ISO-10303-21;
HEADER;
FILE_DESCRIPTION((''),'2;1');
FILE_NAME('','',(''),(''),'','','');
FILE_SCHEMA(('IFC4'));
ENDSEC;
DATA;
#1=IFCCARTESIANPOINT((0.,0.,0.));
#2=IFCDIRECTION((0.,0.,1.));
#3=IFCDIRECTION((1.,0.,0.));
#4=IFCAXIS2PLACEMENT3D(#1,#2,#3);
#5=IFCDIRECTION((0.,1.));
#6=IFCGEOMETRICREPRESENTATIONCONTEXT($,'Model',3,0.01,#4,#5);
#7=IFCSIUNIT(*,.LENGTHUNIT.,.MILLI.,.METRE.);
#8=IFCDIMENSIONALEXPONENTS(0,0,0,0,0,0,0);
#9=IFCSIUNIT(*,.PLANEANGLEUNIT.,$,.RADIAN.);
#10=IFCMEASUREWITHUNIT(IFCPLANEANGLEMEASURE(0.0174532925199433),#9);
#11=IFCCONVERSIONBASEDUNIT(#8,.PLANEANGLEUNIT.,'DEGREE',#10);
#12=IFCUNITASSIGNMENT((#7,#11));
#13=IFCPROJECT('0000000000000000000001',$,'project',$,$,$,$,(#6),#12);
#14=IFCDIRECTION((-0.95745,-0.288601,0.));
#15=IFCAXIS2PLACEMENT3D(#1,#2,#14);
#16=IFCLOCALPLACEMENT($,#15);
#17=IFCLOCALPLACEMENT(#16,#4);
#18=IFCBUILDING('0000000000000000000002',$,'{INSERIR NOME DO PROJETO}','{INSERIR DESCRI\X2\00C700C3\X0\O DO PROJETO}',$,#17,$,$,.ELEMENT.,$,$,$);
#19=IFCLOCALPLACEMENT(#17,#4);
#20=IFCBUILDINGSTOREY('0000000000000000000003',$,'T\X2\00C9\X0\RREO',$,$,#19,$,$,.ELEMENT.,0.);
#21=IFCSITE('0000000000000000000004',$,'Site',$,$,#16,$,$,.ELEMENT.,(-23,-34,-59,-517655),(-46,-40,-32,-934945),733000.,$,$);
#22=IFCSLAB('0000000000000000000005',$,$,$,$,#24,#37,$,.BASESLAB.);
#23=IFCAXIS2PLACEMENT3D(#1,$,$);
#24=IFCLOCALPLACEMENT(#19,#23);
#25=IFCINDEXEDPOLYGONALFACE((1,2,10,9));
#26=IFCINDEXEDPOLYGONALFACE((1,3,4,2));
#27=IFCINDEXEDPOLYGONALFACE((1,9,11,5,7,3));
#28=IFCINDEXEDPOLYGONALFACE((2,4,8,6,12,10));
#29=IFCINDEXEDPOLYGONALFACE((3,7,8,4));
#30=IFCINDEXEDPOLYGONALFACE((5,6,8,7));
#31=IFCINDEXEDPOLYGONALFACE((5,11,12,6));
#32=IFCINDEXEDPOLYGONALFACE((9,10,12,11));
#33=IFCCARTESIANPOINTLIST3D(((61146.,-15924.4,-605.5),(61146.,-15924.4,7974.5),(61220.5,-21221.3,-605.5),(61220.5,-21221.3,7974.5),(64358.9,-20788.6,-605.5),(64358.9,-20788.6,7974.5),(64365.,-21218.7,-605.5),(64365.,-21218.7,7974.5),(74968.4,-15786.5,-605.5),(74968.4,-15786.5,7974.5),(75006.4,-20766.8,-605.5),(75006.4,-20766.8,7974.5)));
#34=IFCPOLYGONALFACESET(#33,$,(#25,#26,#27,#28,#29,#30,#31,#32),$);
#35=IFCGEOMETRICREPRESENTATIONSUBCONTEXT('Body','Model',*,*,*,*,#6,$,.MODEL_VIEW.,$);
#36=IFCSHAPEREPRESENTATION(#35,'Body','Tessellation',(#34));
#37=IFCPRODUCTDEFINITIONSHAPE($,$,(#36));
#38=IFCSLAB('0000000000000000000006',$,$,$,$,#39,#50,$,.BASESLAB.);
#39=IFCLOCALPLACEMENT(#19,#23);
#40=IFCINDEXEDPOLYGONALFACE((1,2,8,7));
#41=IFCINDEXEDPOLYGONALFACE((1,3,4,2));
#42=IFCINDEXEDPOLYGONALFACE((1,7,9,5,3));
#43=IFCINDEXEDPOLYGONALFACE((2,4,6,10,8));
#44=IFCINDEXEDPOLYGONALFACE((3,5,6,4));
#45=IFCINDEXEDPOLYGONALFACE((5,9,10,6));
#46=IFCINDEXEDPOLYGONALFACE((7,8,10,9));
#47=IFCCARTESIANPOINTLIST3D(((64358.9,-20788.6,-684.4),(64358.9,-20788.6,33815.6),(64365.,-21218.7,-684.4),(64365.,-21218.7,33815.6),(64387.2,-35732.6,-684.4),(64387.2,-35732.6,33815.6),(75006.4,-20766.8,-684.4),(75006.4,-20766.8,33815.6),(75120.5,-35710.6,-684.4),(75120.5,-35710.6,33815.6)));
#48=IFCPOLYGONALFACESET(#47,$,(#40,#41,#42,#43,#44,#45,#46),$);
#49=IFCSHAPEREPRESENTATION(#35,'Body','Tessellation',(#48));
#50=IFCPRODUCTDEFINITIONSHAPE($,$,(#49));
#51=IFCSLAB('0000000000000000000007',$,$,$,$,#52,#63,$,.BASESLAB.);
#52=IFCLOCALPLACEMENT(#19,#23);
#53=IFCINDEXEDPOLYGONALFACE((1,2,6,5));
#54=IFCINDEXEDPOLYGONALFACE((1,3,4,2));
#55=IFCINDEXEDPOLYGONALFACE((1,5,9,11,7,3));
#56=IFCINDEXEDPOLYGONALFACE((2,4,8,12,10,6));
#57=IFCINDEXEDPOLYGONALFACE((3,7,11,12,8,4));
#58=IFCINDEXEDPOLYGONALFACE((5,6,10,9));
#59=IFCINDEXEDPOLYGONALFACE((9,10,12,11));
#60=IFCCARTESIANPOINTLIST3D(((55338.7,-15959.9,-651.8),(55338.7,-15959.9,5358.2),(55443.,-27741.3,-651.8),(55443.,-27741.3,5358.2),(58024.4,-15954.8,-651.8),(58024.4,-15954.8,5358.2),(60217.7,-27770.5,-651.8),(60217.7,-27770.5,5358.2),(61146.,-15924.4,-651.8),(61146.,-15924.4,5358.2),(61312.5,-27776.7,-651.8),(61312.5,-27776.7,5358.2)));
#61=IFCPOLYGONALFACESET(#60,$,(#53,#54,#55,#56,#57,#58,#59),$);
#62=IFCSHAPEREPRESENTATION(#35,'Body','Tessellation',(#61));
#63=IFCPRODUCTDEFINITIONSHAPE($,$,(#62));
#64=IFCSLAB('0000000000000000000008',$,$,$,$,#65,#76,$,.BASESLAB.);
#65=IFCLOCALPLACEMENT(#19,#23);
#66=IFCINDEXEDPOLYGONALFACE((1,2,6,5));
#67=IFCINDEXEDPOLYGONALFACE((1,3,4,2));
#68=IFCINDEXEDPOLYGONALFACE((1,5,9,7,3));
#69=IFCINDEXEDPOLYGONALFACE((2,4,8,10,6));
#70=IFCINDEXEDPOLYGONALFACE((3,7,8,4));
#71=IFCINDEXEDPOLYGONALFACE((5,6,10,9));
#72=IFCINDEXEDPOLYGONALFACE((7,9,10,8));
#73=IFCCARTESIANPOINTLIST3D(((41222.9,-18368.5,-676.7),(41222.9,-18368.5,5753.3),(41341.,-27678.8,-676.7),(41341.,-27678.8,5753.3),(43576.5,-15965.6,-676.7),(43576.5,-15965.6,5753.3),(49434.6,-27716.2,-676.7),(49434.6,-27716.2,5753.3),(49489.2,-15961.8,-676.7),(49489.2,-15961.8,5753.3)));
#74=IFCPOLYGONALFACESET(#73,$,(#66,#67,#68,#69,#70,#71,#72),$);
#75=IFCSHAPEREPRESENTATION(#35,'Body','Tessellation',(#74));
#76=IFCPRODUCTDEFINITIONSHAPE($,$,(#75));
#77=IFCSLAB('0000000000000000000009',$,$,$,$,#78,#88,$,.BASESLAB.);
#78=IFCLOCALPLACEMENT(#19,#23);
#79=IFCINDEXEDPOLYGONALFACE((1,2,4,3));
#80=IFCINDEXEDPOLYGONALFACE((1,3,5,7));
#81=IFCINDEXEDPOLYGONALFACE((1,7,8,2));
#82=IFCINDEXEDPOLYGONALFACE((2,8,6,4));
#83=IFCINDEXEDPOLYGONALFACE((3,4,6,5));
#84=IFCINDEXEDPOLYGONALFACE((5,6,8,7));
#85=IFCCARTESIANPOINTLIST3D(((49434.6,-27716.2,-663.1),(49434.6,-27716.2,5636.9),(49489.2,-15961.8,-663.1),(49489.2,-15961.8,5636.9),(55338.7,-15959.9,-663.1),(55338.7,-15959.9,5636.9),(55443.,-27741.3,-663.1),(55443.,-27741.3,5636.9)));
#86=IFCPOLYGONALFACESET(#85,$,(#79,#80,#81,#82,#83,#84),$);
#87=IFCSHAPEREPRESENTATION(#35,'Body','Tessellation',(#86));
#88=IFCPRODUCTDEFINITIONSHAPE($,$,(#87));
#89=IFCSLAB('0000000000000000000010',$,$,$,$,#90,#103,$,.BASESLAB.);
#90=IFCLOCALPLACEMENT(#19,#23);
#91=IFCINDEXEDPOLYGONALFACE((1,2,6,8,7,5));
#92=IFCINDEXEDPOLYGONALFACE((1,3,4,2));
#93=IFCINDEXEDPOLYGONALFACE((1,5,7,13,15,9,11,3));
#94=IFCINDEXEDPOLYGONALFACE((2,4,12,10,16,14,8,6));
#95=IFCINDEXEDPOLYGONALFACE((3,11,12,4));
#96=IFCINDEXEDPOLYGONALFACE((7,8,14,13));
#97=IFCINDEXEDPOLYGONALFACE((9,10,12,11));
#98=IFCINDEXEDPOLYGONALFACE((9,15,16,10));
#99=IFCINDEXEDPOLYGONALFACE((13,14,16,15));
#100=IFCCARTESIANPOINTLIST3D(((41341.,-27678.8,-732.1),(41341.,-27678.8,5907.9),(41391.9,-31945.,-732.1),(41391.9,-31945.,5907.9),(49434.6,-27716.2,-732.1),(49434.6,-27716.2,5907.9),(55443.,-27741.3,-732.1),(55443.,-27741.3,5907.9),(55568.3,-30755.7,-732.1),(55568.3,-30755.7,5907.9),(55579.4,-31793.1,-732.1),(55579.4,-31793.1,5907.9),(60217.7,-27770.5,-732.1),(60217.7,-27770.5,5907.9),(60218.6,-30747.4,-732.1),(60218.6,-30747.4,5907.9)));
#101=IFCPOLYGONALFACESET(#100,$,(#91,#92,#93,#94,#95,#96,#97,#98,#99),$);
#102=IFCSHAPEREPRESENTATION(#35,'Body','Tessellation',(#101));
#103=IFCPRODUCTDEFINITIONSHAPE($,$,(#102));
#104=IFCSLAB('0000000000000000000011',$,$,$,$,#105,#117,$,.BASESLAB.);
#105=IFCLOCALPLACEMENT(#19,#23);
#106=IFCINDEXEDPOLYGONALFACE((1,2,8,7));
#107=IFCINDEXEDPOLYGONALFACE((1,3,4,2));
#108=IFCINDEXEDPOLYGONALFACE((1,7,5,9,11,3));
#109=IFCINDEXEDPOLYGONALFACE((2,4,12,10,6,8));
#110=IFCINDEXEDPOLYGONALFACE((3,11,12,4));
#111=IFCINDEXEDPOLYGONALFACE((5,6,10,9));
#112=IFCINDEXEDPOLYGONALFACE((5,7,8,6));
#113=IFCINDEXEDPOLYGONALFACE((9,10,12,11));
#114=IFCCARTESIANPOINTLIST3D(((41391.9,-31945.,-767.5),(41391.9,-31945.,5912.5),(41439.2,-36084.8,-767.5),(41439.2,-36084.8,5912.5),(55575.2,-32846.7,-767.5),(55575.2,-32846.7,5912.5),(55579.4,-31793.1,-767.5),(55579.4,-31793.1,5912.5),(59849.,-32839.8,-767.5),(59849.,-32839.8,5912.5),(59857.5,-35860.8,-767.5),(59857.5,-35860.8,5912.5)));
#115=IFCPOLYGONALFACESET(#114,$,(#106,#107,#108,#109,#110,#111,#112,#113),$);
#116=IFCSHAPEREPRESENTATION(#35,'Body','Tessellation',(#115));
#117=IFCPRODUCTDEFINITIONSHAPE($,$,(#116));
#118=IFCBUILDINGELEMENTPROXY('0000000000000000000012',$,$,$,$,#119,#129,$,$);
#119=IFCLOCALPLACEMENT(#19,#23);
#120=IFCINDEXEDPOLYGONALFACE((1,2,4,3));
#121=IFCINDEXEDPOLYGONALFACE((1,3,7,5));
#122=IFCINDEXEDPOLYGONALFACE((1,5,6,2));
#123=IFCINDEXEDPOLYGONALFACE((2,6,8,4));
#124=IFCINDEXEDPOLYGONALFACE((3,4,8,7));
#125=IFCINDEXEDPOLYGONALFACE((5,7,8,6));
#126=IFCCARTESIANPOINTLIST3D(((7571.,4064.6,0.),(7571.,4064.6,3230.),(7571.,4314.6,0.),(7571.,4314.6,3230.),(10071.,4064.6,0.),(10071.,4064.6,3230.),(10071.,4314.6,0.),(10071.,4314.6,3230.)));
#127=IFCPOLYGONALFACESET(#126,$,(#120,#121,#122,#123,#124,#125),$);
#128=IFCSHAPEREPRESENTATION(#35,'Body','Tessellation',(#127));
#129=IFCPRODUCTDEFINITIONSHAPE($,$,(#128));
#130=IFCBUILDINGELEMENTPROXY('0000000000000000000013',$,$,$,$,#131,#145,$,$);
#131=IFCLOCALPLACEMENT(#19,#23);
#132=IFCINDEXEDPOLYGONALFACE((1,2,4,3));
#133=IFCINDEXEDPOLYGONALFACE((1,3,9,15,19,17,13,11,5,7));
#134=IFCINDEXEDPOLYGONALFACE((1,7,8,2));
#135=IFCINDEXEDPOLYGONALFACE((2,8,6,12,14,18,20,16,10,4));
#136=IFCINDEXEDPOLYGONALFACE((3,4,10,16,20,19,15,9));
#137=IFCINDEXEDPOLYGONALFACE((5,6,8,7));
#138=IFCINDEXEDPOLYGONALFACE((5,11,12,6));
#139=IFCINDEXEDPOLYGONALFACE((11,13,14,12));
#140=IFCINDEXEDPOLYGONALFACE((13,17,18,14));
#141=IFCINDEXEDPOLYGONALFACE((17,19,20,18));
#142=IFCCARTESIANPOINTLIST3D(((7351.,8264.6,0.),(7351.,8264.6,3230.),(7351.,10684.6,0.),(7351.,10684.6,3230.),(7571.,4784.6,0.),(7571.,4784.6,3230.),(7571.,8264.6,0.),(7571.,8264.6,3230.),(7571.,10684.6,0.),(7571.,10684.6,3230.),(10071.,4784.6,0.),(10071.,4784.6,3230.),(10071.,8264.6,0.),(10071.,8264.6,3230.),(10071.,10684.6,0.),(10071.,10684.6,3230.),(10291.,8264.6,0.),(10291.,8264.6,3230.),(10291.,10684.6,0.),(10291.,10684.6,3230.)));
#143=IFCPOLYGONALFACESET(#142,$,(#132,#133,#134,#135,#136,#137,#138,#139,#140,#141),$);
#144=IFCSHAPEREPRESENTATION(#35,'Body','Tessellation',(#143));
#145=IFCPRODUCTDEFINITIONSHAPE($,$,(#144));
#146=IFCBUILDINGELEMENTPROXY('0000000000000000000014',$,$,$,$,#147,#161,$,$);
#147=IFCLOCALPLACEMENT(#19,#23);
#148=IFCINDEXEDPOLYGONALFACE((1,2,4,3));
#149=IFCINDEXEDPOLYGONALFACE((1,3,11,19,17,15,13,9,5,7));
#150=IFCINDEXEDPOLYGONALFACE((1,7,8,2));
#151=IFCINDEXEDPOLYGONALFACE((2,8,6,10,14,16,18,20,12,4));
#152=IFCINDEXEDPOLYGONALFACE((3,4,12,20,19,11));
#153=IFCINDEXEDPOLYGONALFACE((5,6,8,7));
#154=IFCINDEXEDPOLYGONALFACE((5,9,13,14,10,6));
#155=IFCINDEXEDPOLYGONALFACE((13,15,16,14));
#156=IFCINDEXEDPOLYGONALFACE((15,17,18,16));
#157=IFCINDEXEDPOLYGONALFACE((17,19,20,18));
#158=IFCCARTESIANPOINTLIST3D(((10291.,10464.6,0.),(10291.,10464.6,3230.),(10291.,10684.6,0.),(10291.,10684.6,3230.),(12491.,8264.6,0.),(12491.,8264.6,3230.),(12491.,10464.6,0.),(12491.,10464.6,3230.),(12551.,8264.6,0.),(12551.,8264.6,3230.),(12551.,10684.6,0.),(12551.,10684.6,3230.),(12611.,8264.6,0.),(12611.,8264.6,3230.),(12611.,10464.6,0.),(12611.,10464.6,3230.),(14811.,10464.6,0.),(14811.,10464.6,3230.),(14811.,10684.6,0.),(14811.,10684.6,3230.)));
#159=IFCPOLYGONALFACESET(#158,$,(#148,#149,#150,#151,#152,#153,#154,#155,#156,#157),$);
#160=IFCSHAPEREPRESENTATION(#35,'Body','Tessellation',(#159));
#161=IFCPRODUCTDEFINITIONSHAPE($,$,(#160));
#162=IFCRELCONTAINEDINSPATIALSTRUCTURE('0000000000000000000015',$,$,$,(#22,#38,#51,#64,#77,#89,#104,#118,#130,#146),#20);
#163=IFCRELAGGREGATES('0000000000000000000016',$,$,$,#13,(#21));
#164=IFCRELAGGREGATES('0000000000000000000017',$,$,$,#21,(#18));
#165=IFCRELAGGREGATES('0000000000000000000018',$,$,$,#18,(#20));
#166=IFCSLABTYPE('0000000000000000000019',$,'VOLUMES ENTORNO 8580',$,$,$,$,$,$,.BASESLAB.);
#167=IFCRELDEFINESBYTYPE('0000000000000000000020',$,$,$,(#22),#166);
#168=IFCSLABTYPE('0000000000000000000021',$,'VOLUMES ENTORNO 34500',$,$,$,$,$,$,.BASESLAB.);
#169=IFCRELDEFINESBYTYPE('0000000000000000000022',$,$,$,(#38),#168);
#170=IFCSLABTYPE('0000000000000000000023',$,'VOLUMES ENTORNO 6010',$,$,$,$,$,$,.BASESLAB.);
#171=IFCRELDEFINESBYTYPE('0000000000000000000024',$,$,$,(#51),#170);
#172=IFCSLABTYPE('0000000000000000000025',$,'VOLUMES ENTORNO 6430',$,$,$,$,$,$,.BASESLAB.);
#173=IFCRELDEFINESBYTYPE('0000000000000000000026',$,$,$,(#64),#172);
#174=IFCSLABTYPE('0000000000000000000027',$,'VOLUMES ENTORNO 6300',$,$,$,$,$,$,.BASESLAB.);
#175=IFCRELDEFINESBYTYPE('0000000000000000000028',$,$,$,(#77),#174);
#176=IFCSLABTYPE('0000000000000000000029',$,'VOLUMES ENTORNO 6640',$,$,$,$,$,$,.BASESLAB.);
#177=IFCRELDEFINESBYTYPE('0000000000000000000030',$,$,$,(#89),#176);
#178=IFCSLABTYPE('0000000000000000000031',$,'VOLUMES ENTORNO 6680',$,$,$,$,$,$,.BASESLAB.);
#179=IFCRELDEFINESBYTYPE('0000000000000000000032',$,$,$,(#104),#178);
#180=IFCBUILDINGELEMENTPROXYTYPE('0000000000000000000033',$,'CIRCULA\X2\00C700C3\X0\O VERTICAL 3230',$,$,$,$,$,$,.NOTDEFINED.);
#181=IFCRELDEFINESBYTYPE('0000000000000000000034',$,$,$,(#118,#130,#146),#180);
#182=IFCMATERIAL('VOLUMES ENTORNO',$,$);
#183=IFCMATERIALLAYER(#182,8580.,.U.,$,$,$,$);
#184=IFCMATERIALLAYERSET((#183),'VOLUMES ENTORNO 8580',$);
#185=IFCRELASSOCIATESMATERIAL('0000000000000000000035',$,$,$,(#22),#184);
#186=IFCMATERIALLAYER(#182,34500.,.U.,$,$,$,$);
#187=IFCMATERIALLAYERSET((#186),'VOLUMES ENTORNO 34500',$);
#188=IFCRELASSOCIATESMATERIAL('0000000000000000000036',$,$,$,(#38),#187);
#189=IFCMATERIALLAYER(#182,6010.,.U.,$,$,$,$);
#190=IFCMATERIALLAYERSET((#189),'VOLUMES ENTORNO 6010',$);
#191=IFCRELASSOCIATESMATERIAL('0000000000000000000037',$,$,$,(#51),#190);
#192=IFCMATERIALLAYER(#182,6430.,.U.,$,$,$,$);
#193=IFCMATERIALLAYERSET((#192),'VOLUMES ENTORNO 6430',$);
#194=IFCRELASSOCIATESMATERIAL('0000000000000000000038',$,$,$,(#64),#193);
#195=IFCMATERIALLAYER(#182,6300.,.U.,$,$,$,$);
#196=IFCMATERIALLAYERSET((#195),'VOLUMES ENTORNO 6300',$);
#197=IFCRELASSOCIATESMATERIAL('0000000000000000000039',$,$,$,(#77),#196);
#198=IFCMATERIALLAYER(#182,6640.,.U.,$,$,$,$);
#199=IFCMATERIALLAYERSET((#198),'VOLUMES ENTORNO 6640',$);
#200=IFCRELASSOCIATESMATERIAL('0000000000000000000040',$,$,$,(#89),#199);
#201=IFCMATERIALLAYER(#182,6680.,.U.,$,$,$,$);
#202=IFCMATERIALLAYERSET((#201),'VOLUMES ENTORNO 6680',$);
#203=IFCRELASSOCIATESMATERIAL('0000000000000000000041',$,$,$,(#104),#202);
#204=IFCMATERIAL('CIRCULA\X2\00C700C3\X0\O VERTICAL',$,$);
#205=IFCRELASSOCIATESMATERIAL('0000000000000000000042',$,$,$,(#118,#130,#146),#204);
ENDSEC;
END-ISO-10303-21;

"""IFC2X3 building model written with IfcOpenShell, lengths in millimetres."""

from ifc_helpers import new_model, entity, si_unit, converted_unit, direction, frame, origin_with_axes, place, context, subcontext, project, spatial, polyline, outline, extrude, material, layer, layer_set, layer_usage, type_object, element, save


model = new_model("IFC2X3")

# Units and contexts
model_context = context("Model", 3, precision=0.01, world=origin_with_axes(), true_north=direction((0.0, 1.0)))
body_context = subcontext(model_context, "Body", "Model", "MODEL_VIEW")
ifc_project = project(units=[si_unit("LENGTHUNIT", "METRE", prefix="MILLI"), converted_unit("PLANEANGLEUNIT", "DEGREE", entity("IfcPlaneAngleMeasure", 0.0174532925199433), si_unit("PLANEANGLEUNIT", "RADIAN"), dimensions=[0, 0, 0, 0, 0, 0, 0])], contexts=[model_context])

# Site, building, storey
site_placement = place(None, frame((0.0, 0.0, 0.0), z_axis=(0.0, 0.0, 1.0), x_axis=(-0.95745, -0.288601, 0.0)))
site = spatial("IfcSite", under=ifc_project, at=site_placement, Name="Site", CompositionType="ELEMENT", RefLatitude=(-23, -34, -59, -517655), RefLongitude=(-46, -40, -32, -934945), RefElevation=733000.0)
building_placement = place(site_placement, origin_with_axes())
building = spatial("IfcBuilding", under=site, at=building_placement, Name="{INSERIR NOME DO PROJETO}", Description="{INSERIR DESCRIÇÃO DO PROJETO}", CompositionType="ELEMENT")
storey_placement = place(building_placement, origin_with_axes())
storey = spatial("IfcBuildingStorey", under=building, at=storey_placement, Name="TÉRREO", CompositionType="ELEMENT", Elevation=0.0)

# Slabs
ifc_material_1 = material(Name="VOLUMES ENTORNO")
ifc_layer_1 = layer(ifc_material_1, 8580.0, ventilated="UNKNOWN")
ifc_layer_set_1 = layer_set([ifc_layer_1], Name="VOLUMES ENTORNO 8580")
ifc_layer_usage_1 = layer_usage(ifc_layer_set_1, "AXIS3", "NEGATIVE", 8580.0)
slab_type_1 = type_object("IfcSlabType", Name="VOLUMES ENTORNO 8580", PredefinedType="BASESLAB")
slab_1_placement = place(storey_placement, frame((61220.5, -21221.3, -605.5), z_axis=(0.0, 0.0, 1.0), x_axis=(1.0, 0.0, 0.0)))
element("IfcSlab", 1, at=slab_1_placement, inside=storey, type_object=slab_type_1, material=ifc_layer_usage_1, PredefinedType="BASESLAB", context=body_context, shape_type="SweptSolid", body=[
    extrude(outline(polyline([(0.0, 0.0), (3144.5, 2.6), (3138.4, 432.7), (13785.9, 454.5), (13747.9, 5434.7), (-74.5, 5296.9), (0.0, 0.0)])), origin_with_axes(), (0.0, 0.0, 1.0), 8580.0),
])
ifc_layer_2 = layer(ifc_material_1, 34500.0, ventilated="UNKNOWN")
ifc_layer_set_2 = layer_set([ifc_layer_2], Name="VOLUMES ENTORNO 34500")
ifc_layer_usage_2 = layer_usage(ifc_layer_set_2, "AXIS3", "NEGATIVE", 34500.0)
slab_type_2 = type_object("IfcSlabType", Name="VOLUMES ENTORNO 34500", PredefinedType="BASESLAB")
slab_2_placement = place(storey_placement, frame((64387.2, -35732.6, -684.4), z_axis=(0.0, 0.0, 1.0), x_axis=(1.0, 0.0, 0.0)))
element("IfcSlab", 2, at=slab_2_placement, inside=storey, type_object=slab_type_2, material=ifc_layer_usage_2, PredefinedType="BASESLAB", context=body_context, shape_type="SweptSolid", body=[
    extrude(outline(polyline([(0.0, 0.0), (10733.2, 22.0), (10619.1, 14965.9), (-28.3, 14944.1), (-22.2, 14514.0), (0.0, 0.0)])), origin_with_axes(), (0.0, 0.0, 1.0), 34500.0),
])
ifc_layer_3 = layer(ifc_material_1, 6010.0, ventilated="UNKNOWN")
ifc_layer_set_3 = layer_set([ifc_layer_3], Name="VOLUMES ENTORNO 6010")
ifc_layer_usage_3 = layer_usage(ifc_layer_set_3, "AXIS3", "NEGATIVE", 6010.0)
slab_type_3 = type_object("IfcSlabType", Name="VOLUMES ENTORNO 6010", PredefinedType="BASESLAB")
slab_3_placement = place(storey_placement, frame((61312.5, -27776.7, -651.8), z_axis=(0.0, 0.0, 1.0), x_axis=(1.0, 0.0, 0.0)))
element("IfcSlab", 3, at=slab_3_placement, inside=storey, type_object=slab_type_3, material=ifc_layer_usage_3, PredefinedType="BASESLAB", context=body_context, shape_type="SweptSolid", body=[
    extrude(outline(polyline([(0.0, 0.0), (-166.5, 11852.4), (-3288.1, 11822.0), (-5973.8, 11816.9), (-5869.5, 35.5), (-1094.8, 6.2), (0.0, 0.0)])), origin_with_axes(), (0.0, 0.0, 1.0), 6010.0),
])
ifc_layer_4 = layer(ifc_material_1, 6430.0, ventilated="UNKNOWN")
ifc_layer_set_4 = layer_set([ifc_layer_4], Name="VOLUMES ENTORNO 6430")
ifc_layer_usage_4 = layer_usage(ifc_layer_set_4, "AXIS3", "NEGATIVE", 6430.0)
slab_type_4 = type_object("IfcSlabType", Name="VOLUMES ENTORNO 6430", PredefinedType="BASESLAB")
slab_4_placement = place(storey_placement, frame((41222.9, -18368.5, -676.7), z_axis=(0.0, 0.0, 1.0), x_axis=(1.0, 0.0, 0.0)))
element("IfcSlab", 4, at=slab_4_placement, inside=storey, type_object=slab_type_4, material=ifc_layer_usage_4, PredefinedType="BASESLAB", context=body_context, shape_type="SweptSolid", body=[
    extrude(outline(polyline([(0.0, 0.0), (118.1, -9310.2), (8211.7, -9347.6), (8266.3, 2406.7), (2353.7, 2403.0), (0.0, 0.0)])), origin_with_axes(), (0.0, 0.0, 1.0), 6430.0),
])
ifc_layer_5 = layer(ifc_material_1, 6300.0, ventilated="UNKNOWN")
ifc_layer_set_5 = layer_set([ifc_layer_5], Name="VOLUMES ENTORNO 6300")
ifc_layer_usage_5 = layer_usage(ifc_layer_set_5, "AXIS3", "NEGATIVE", 6300.0)
slab_type_5 = type_object("IfcSlabType", Name="VOLUMES ENTORNO 6300", PredefinedType="BASESLAB")
slab_5_placement = place(storey_placement, frame((55443.0, -27741.3, -663.1), z_axis=(0.0, 0.0, 1.0), x_axis=(1.0, 0.0, 0.0)))
element("IfcSlab", 5, at=slab_5_placement, inside=storey, type_object=slab_type_5, material=ifc_layer_usage_5, PredefinedType="BASESLAB", context=body_context, shape_type="SweptSolid", body=[
    extrude(outline(polyline([(0.0, 0.0), (-104.3, 11781.4), (-5953.8, 11779.5), (-6008.4, 25.1), (0.0, 0.0)])), origin_with_axes(), (0.0, 0.0, 1.0), 6300.0),
])
ifc_layer_6 = layer(ifc_material_1, 6640.0, ventilated="UNKNOWN")
ifc_layer_set_6 = layer_set([ifc_layer_6], Name="VOLUMES ENTORNO 6640")
ifc_layer_usage_6 = layer_usage(ifc_layer_set_6, "AXIS3", "NEGATIVE", 6640.0)
slab_type_6 = type_object("IfcSlabType", Name="VOLUMES ENTORNO 6640", PredefinedType="BASESLAB")
slab_6_placement = place(storey_placement, frame((41341.0, -27678.8, -732.1), z_axis=(0.0, 0.0, 1.0), x_axis=(1.0, 0.0, 0.0)))
element("IfcSlab", 6, at=slab_6_placement, inside=storey, type_object=slab_type_6, material=ifc_layer_usage_6, PredefinedType="BASESLAB", context=body_context, shape_type="SweptSolid", body=[
    extrude(outline(polyline([(0.0, 0.0), (50.9, -4266.2), (14238.5, -4114.3), (14227.4, -3077.0), (18877.6, -3068.7), (18876.7, -91.7), (14102.0, -62.5), (8093.6, -37.4), (0.0, 0.0)])), origin_with_axes(), (0.0, 0.0, 1.0), 6640.0),
])
ifc_layer_7 = layer(ifc_material_1, 6680.0, ventilated="UNKNOWN")
ifc_layer_set_7 = layer_set([ifc_layer_7], Name="VOLUMES ENTORNO 6680")
ifc_layer_usage_7 = layer_usage(ifc_layer_set_7, "AXIS3", "NEGATIVE", 6680.0)
slab_type_7 = type_object("IfcSlabType", Name="VOLUMES ENTORNO 6680", PredefinedType="BASESLAB")
slab_7_placement = place(storey_placement, frame((41391.9, -31945.0, -767.5), z_axis=(0.0, 0.0, 1.0), x_axis=(1.0, 0.0, 0.0)))
element("IfcSlab", 7, at=slab_7_placement, inside=storey, type_object=slab_type_7, material=ifc_layer_usage_7, PredefinedType="BASESLAB", context=body_context, shape_type="SweptSolid", body=[
    extrude(outline(polyline([(0.0, 0.0), (47.3, -4139.8), (18465.6, -3915.8), (18457.1, -894.8), (14183.3, -901.7), (14187.5, 151.9), (0.0, 0.0)])), origin_with_axes(), (0.0, 0.0, 1.0), 6680.0),
])

# Building element proxies
ifc_material_2 = material(Name="CIRCULAÇÃO VERTICAL")
building_element_proxy_type_1 = type_object("IfcBuildingElementProxyType", Name="CIRCULAÇÃO VERTICAL 3230", PredefinedType="NOTDEFINED")
proxy_1_placement = place(storey_placement, frame((7571.0, 4064.6, 0.0), z_axis=(0.0, 0.0, 1.0), x_axis=(1.0, 0.0, 0.0)))
element("IfcBuildingElementProxy", 8, at=proxy_1_placement, inside=storey, type_object=building_element_proxy_type_1, material=ifc_material_2, context=body_context, shape_type="SweptSolid", body=[
    extrude(outline(polyline([(0.0, 0.0), (2500.0, 0.0), (2500.0, 250.0), (0.0, 250.0), (0.0, 0.0)])), origin_with_axes(), (0.0, 0.0, 1.0), 3230.0),
])
proxy_2_placement = place(storey_placement, frame((7351.0, 10684.6, 0.0), z_axis=(0.0, 0.0, 1.0), x_axis=(1.0, 0.0, 0.0)))
element("IfcBuildingElementProxy", 9, at=proxy_2_placement, inside=storey, type_object=building_element_proxy_type_1, material=ifc_material_2, context=body_context, shape_type="SweptSolid", body=[
    extrude(outline(polyline([(0.0, 0.0), (0.0, -2420.0), (220.0, -2420.0), (220.0, -5900.0), (2720.0, -5900.0), (2720.0, -2420.0), (2940.0, -2420.0), (2940.0, 0.0), (2720.0, 0.0), (220.0, 0.0), (0.0, 0.0)])), origin_with_axes(), (0.0, 0.0, 1.0), 3230.0),
])
proxy_3_placement = place(storey_placement, frame((10291.0, 10684.6, 0.0), z_axis=(0.0, 0.0, 1.0), x_axis=(1.0, 0.0, 0.0)))
element("IfcBuildingElementProxy", 10, at=proxy_3_placement, inside=storey, type_object=building_element_proxy_type_1, material=ifc_material_2, context=body_context, shape_type="SweptSolid", body=[
    extrude(outline(polyline([(0.0, 0.0), (0.0, -220.0), (2200.0, -220.0), (2200.0, -2420.0), (2260.0, -2420.0), (2320.0, -2420.0), (2320.0, -220.0), (4520.0, -220.0), (4520.0, 0.0), (2260.0, 0.0), (0.0, 0.0)])), origin_with_axes(), (0.0, 0.0, 1.0), 3230.0),
])

save(model, "model.ifc")
